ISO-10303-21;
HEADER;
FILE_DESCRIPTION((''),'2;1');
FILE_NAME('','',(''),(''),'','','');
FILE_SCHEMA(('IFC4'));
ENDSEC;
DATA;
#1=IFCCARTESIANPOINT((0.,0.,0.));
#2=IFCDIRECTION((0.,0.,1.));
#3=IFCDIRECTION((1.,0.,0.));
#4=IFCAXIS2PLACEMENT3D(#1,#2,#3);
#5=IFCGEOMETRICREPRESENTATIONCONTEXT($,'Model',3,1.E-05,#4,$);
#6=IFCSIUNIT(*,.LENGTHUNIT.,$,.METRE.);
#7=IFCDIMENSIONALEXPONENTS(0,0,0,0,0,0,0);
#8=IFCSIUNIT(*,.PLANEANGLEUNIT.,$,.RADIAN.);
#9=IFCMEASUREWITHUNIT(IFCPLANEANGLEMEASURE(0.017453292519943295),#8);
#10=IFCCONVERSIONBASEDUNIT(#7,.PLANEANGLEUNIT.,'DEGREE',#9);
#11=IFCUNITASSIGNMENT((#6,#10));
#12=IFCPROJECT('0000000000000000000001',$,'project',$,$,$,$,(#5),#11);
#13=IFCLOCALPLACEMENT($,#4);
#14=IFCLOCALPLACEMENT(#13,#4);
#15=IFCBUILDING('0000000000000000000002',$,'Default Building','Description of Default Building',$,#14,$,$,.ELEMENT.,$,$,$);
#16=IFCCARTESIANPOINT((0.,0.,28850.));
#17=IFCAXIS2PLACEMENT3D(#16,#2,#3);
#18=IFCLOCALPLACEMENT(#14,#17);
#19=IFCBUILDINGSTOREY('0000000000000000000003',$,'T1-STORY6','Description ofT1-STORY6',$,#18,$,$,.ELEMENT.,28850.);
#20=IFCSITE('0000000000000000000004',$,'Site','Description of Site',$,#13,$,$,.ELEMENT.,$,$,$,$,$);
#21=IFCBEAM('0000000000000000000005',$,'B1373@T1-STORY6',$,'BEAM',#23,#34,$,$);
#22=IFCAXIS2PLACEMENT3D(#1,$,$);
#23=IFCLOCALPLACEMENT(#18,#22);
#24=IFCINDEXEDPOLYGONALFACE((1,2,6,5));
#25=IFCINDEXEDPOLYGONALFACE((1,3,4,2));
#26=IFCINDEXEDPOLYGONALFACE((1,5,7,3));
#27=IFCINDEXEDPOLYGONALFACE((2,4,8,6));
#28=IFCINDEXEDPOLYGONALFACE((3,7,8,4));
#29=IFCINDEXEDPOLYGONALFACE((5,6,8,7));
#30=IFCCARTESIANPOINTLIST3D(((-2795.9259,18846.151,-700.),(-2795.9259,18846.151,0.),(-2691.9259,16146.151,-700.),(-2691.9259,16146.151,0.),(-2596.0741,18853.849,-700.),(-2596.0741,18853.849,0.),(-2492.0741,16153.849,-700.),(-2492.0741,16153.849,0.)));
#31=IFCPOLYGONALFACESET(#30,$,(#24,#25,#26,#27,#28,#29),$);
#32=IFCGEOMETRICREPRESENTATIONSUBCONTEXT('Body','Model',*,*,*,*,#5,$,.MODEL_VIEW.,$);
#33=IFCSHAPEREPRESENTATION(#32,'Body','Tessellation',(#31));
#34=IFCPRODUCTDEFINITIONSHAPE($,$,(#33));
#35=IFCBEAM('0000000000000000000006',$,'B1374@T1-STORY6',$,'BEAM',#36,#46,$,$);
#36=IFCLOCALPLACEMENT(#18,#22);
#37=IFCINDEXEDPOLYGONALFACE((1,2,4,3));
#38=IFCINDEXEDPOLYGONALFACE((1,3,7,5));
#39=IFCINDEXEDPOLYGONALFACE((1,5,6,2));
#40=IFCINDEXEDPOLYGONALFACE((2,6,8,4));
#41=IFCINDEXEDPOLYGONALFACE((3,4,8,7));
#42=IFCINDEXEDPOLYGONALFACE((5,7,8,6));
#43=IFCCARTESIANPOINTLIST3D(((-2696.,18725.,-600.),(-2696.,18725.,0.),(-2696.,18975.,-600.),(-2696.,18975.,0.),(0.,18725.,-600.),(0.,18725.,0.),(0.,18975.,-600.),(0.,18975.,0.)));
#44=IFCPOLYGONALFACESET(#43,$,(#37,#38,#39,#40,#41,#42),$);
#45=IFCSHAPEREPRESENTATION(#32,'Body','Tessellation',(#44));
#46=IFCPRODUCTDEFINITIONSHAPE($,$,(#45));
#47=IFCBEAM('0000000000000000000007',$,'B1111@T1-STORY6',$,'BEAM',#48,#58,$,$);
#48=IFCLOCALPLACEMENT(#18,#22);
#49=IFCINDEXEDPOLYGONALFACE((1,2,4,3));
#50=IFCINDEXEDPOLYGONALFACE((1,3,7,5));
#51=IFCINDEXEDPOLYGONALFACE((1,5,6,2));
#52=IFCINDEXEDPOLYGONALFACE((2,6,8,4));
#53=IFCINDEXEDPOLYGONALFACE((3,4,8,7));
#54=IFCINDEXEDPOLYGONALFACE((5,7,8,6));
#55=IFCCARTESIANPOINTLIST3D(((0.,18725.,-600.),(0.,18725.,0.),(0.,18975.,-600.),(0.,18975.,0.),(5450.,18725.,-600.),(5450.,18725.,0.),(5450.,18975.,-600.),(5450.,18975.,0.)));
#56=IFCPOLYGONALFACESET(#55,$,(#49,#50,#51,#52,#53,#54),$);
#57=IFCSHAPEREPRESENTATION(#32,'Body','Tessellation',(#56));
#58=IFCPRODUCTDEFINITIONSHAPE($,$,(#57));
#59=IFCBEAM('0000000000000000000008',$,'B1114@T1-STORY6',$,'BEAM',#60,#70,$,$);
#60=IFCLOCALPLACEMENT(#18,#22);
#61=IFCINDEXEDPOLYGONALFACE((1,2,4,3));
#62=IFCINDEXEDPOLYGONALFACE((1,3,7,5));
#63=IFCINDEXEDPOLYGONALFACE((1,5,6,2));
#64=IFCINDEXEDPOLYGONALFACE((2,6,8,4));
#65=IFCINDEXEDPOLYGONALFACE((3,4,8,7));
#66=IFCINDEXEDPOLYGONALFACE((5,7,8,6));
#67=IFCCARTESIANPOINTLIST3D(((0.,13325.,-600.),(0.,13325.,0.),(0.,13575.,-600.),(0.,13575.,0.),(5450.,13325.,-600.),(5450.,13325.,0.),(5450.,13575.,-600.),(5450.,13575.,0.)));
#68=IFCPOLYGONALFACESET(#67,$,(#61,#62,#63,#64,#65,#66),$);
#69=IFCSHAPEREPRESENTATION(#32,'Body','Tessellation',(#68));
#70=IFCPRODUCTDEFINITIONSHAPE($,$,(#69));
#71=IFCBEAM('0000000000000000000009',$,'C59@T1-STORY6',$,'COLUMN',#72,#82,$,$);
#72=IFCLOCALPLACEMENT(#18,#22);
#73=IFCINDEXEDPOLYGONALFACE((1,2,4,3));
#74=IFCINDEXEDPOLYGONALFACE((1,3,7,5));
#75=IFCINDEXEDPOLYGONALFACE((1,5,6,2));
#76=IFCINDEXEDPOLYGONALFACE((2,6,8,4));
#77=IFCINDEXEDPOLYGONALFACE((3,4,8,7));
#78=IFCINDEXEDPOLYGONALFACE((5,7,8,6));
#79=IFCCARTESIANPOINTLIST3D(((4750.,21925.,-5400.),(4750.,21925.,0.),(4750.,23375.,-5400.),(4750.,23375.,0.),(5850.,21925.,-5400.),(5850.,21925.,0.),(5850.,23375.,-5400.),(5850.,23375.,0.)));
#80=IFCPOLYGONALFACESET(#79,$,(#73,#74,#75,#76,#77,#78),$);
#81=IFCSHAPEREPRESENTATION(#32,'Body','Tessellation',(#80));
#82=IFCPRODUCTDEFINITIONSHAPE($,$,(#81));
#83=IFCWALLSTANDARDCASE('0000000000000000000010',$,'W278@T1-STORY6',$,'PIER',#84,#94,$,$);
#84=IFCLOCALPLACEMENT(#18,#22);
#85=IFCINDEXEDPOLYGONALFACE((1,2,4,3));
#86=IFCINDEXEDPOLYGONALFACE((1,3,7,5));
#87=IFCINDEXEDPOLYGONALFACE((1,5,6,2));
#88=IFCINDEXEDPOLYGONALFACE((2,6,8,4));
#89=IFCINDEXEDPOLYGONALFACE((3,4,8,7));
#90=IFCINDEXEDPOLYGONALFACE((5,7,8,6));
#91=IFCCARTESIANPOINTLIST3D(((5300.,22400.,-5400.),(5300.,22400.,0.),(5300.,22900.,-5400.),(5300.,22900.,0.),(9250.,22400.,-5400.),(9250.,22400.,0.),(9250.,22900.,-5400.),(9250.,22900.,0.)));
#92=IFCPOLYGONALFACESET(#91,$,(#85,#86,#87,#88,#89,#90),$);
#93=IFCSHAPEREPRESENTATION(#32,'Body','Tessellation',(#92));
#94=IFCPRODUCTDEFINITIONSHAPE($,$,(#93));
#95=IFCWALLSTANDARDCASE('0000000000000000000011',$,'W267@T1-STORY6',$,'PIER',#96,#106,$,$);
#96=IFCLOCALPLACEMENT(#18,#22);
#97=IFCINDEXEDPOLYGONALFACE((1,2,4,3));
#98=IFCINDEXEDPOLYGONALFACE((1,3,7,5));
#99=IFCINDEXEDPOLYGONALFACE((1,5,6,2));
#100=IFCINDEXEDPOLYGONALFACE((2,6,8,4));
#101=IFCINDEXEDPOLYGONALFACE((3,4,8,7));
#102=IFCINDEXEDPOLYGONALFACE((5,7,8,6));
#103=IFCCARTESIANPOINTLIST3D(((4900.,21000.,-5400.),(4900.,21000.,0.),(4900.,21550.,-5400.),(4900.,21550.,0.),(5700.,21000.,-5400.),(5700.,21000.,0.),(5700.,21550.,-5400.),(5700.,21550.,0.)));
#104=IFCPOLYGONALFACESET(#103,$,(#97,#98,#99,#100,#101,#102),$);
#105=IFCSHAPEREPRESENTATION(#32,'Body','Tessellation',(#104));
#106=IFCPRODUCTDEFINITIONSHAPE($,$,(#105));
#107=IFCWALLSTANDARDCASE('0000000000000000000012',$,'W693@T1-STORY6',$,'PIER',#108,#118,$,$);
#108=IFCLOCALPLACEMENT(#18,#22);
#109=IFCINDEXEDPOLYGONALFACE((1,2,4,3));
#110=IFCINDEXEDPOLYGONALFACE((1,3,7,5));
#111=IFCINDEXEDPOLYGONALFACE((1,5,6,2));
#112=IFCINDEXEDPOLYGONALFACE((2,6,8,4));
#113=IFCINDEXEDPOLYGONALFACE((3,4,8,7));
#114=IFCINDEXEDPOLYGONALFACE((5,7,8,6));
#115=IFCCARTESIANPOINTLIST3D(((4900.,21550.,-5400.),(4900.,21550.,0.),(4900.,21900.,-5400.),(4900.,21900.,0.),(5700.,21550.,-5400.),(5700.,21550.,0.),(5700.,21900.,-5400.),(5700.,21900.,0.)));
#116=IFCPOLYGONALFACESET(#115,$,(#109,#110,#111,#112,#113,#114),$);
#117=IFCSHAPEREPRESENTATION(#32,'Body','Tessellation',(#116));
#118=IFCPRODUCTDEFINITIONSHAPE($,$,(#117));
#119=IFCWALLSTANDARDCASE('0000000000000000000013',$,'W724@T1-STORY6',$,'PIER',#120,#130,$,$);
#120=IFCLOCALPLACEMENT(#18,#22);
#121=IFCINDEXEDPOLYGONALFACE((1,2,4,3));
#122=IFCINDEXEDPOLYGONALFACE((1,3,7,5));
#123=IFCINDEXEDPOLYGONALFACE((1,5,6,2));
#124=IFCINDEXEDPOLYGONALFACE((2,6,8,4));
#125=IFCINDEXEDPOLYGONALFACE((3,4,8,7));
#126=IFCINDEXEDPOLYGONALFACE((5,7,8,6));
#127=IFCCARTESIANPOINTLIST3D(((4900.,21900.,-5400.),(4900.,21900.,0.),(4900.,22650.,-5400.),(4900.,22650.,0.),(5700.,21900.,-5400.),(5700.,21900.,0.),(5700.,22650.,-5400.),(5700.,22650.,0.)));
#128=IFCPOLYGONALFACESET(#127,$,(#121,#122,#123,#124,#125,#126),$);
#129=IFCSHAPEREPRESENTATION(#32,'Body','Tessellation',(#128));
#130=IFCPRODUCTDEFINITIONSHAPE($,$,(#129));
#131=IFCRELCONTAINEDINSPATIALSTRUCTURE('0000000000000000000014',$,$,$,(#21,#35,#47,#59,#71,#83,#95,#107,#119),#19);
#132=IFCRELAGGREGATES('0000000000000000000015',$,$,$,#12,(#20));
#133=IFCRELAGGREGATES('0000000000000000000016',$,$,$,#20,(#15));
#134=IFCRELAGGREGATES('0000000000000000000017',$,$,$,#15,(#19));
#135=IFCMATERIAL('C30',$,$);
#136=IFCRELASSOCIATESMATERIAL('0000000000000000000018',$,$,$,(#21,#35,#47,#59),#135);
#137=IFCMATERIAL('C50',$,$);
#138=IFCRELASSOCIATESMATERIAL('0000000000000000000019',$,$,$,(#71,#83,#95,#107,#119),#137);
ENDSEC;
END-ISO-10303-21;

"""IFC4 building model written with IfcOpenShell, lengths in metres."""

from ifc_helpers import new_model, entity, si_unit, converted_unit, frame, origin_with_axes, place, context, subcontext, project, spatial, indexed_curve, rectangle, outline, extrude, material, element, save


model = new_model("IFC4")

# Units and contexts
model_context = context("Model", 3, precision=1e-05, world=origin_with_axes())
body_context = subcontext(model_context, "Body", "Model", "MODEL_VIEW")
ifc_project = project(units=[si_unit("LENGTHUNIT", "METRE"), converted_unit("PLANEANGLEUNIT", "DEGREE", entity("IfcPlaneAngleMeasure", 0.017453292519943295), si_unit("PLANEANGLEUNIT", "RADIAN"), dimensions=[0, 0, 0, 0, 0, 0, 0])], contexts=[model_context])

# Site, building, storey
site_placement = place(None, origin_with_axes())
site = spatial("IfcSite", under=ifc_project, at=site_placement, Name="Site", Description="Description of Site", CompositionType="ELEMENT")
building_placement = place(site_placement, origin_with_axes())
building = spatial("IfcBuilding", under=site, at=building_placement, Name="Default Building", Description="Description of Default Building", CompositionType="ELEMENT")
storey_placement = place(building_placement, frame((0.0, 0.0, 28850.0), z_axis=(0.0, 0.0, 1.0), x_axis=(1.0, 0.0, 0.0)))
storey = spatial("IfcBuildingStorey", under=building, at=storey_placement, Name="T1-STORY6", Description="Description ofT1-STORY6", CompositionType="ELEMENT", Elevation=28850.0)

# Beams
ifc_material_1 = material(Name="C30")
beam_1_placement = place(storey_placement, frame((-2696.0, 18850.0, -350.0), z_axis=(0.03849, -0.999259, 0.0), x_axis=(0.999259, 0.03849, 0.0)))
element("IfcBeam", 1, at=beam_1_placement, inside=storey, material=ifc_material_1, Name="B1373@T1-STORY6", ObjectType="BEAM", context=body_context, shape_type="SweptSolid", body=[
    extrude(rectangle(XDim=200.0, YDim=700.0), origin_with_axes(), (0.0, 0.0, 1.0), 2702.0022),
])
beam_2_placement = place(storey_placement, frame((-2696.0, 18850.0, -300.0), z_axis=(1.0, 0.0, 0.0), x_axis=(0.0, 1.0, 0.0)))
element("IfcBeam", 2, at=beam_2_placement, inside=storey, material=ifc_material_1, Name="B1374@T1-STORY6", ObjectType="BEAM", context=body_context, shape_type="SweptSolid", body=[
    extrude(rectangle(XDim=250.0, YDim=600.0), origin_with_axes(), (0.0, 0.0, 1.0), 2696.0),
])
for number, where, z_axis, x_axis, name in (
    (3, (0.0, 18850.0, -300.0), (1.0, 0.0, 0.0), (0.0, 1.0, 0.0), "B1111@T1-STORY6"),
    (4, (0.0, 13450.0, -300.0), (1.0, 0.0, 0.0), (0.0, 1.0, 0.0), "B1114@T1-STORY6"),
):
    element("IfcBeam", number, at=place(storey_placement, frame(where, z_axis=z_axis, x_axis=x_axis)), inside=storey, material=ifc_material_1, Name=name, ObjectType="BEAM", context=body_context, shape_type="SweptSolid", body=[
        extrude(rectangle(XDim=250.0, YDim=600.0), origin_with_axes(), (0.0, 0.0, 1.0), 5450.0),
    ])
ifc_material_2 = material(Name="C50")
beam_3_placement = place(storey_placement, frame((5300.0, 22650.0, -5400.0), z_axis=(0.0, 0.0, 1.0), x_axis=(-1.0, 0.0, 0.0)))
element("IfcBeam", 5, at=beam_3_placement, inside=storey, material=ifc_material_2, Name="C59@T1-STORY6", ObjectType="COLUMN", context=body_context, shape_type="SweptSolid", body=[
    extrude(rectangle(XDim=1100.0, YDim=1450.0), origin_with_axes(), (0.0, 0.0, 1.0), 5400.0),
])

# Walls
wall_1_placement = place(storey_placement, frame((5300.0, 22650.0, -5400.0), z_axis=(0.0, 0.0, 1.0), x_axis=(1.0, 0.0, 0.0)))
element("IfcWallStandardCase", 6, at=wall_1_placement, inside=storey, material=ifc_material_2, Name="W278@T1-STORY6", ObjectType="PIER", context=body_context, shape_type="SweptSolid", body=[
    extrude(outline(indexed_curve([(0.0, -250.0), (0.0, 250.0), (3950.0, 250.0), (3950.0, -250.0), (0.0, -250.0)], self_intersect=False)), origin_with_axes(), (0.0, 0.0, 1.0), 5400.0),
])
wall_2_placement = place(storey_placement, frame((5300.0, 21000.0, -5400.0), z_axis=(0.0, 0.0, 1.0), x_axis=(0.0, 1.0, 0.0)))
element("IfcWallStandardCase", 7, at=wall_2_placement, inside=storey, material=ifc_material_2, Name="W267@T1-STORY6", ObjectType="PIER", context=body_context, shape_type="SweptSolid", body=[
    extrude(outline(indexed_curve([(0.0, -400.0), (0.0, 400.0), (550.0, 400.0), (550.0, -400.0), (0.0, -400.0)], self_intersect=False)), origin_with_axes(), (0.0, 0.0, 1.0), 5400.0),
])
wall_3_placement = place(storey_placement, frame((5300.0, 21550.0, -5400.0), z_axis=(0.0, 0.0, 1.0), x_axis=(0.0, 1.0, 0.0)))
element("IfcWallStandardCase", 8, at=wall_3_placement, inside=storey, material=ifc_material_2, Name="W693@T1-STORY6", ObjectType="PIER", context=body_context, shape_type="SweptSolid", body=[
    extrude(outline(indexed_curve([(0.0, -400.0), (0.0, 400.0), (350.0, 400.0), (350.0, -400.0), (0.0, -400.0)], self_intersect=False)), origin_with_axes(), (0.0, 0.0, 1.0), 5400.0),
])
wall_4_placement = place(storey_placement, frame((5300.0, 21900.0, -5400.0), z_axis=(0.0, 0.0, 1.0), x_axis=(0.0, 1.0, 0.0)))
element("IfcWallStandardCase", 9, at=wall_4_placement, inside=storey, material=ifc_material_2, Name="W724@T1-STORY6", ObjectType="PIER", context=body_context, shape_type="SweptSolid", body=[
    extrude(outline(indexed_curve([(0.0, -400.0), (0.0, 400.0), (750.0, 400.0), (750.0, -400.0), (0.0, -400.0)], self_intersect=False)), origin_with_axes(), (0.0, 0.0, 1.0), 5400.0),
])

save(model, "model.ifc")
